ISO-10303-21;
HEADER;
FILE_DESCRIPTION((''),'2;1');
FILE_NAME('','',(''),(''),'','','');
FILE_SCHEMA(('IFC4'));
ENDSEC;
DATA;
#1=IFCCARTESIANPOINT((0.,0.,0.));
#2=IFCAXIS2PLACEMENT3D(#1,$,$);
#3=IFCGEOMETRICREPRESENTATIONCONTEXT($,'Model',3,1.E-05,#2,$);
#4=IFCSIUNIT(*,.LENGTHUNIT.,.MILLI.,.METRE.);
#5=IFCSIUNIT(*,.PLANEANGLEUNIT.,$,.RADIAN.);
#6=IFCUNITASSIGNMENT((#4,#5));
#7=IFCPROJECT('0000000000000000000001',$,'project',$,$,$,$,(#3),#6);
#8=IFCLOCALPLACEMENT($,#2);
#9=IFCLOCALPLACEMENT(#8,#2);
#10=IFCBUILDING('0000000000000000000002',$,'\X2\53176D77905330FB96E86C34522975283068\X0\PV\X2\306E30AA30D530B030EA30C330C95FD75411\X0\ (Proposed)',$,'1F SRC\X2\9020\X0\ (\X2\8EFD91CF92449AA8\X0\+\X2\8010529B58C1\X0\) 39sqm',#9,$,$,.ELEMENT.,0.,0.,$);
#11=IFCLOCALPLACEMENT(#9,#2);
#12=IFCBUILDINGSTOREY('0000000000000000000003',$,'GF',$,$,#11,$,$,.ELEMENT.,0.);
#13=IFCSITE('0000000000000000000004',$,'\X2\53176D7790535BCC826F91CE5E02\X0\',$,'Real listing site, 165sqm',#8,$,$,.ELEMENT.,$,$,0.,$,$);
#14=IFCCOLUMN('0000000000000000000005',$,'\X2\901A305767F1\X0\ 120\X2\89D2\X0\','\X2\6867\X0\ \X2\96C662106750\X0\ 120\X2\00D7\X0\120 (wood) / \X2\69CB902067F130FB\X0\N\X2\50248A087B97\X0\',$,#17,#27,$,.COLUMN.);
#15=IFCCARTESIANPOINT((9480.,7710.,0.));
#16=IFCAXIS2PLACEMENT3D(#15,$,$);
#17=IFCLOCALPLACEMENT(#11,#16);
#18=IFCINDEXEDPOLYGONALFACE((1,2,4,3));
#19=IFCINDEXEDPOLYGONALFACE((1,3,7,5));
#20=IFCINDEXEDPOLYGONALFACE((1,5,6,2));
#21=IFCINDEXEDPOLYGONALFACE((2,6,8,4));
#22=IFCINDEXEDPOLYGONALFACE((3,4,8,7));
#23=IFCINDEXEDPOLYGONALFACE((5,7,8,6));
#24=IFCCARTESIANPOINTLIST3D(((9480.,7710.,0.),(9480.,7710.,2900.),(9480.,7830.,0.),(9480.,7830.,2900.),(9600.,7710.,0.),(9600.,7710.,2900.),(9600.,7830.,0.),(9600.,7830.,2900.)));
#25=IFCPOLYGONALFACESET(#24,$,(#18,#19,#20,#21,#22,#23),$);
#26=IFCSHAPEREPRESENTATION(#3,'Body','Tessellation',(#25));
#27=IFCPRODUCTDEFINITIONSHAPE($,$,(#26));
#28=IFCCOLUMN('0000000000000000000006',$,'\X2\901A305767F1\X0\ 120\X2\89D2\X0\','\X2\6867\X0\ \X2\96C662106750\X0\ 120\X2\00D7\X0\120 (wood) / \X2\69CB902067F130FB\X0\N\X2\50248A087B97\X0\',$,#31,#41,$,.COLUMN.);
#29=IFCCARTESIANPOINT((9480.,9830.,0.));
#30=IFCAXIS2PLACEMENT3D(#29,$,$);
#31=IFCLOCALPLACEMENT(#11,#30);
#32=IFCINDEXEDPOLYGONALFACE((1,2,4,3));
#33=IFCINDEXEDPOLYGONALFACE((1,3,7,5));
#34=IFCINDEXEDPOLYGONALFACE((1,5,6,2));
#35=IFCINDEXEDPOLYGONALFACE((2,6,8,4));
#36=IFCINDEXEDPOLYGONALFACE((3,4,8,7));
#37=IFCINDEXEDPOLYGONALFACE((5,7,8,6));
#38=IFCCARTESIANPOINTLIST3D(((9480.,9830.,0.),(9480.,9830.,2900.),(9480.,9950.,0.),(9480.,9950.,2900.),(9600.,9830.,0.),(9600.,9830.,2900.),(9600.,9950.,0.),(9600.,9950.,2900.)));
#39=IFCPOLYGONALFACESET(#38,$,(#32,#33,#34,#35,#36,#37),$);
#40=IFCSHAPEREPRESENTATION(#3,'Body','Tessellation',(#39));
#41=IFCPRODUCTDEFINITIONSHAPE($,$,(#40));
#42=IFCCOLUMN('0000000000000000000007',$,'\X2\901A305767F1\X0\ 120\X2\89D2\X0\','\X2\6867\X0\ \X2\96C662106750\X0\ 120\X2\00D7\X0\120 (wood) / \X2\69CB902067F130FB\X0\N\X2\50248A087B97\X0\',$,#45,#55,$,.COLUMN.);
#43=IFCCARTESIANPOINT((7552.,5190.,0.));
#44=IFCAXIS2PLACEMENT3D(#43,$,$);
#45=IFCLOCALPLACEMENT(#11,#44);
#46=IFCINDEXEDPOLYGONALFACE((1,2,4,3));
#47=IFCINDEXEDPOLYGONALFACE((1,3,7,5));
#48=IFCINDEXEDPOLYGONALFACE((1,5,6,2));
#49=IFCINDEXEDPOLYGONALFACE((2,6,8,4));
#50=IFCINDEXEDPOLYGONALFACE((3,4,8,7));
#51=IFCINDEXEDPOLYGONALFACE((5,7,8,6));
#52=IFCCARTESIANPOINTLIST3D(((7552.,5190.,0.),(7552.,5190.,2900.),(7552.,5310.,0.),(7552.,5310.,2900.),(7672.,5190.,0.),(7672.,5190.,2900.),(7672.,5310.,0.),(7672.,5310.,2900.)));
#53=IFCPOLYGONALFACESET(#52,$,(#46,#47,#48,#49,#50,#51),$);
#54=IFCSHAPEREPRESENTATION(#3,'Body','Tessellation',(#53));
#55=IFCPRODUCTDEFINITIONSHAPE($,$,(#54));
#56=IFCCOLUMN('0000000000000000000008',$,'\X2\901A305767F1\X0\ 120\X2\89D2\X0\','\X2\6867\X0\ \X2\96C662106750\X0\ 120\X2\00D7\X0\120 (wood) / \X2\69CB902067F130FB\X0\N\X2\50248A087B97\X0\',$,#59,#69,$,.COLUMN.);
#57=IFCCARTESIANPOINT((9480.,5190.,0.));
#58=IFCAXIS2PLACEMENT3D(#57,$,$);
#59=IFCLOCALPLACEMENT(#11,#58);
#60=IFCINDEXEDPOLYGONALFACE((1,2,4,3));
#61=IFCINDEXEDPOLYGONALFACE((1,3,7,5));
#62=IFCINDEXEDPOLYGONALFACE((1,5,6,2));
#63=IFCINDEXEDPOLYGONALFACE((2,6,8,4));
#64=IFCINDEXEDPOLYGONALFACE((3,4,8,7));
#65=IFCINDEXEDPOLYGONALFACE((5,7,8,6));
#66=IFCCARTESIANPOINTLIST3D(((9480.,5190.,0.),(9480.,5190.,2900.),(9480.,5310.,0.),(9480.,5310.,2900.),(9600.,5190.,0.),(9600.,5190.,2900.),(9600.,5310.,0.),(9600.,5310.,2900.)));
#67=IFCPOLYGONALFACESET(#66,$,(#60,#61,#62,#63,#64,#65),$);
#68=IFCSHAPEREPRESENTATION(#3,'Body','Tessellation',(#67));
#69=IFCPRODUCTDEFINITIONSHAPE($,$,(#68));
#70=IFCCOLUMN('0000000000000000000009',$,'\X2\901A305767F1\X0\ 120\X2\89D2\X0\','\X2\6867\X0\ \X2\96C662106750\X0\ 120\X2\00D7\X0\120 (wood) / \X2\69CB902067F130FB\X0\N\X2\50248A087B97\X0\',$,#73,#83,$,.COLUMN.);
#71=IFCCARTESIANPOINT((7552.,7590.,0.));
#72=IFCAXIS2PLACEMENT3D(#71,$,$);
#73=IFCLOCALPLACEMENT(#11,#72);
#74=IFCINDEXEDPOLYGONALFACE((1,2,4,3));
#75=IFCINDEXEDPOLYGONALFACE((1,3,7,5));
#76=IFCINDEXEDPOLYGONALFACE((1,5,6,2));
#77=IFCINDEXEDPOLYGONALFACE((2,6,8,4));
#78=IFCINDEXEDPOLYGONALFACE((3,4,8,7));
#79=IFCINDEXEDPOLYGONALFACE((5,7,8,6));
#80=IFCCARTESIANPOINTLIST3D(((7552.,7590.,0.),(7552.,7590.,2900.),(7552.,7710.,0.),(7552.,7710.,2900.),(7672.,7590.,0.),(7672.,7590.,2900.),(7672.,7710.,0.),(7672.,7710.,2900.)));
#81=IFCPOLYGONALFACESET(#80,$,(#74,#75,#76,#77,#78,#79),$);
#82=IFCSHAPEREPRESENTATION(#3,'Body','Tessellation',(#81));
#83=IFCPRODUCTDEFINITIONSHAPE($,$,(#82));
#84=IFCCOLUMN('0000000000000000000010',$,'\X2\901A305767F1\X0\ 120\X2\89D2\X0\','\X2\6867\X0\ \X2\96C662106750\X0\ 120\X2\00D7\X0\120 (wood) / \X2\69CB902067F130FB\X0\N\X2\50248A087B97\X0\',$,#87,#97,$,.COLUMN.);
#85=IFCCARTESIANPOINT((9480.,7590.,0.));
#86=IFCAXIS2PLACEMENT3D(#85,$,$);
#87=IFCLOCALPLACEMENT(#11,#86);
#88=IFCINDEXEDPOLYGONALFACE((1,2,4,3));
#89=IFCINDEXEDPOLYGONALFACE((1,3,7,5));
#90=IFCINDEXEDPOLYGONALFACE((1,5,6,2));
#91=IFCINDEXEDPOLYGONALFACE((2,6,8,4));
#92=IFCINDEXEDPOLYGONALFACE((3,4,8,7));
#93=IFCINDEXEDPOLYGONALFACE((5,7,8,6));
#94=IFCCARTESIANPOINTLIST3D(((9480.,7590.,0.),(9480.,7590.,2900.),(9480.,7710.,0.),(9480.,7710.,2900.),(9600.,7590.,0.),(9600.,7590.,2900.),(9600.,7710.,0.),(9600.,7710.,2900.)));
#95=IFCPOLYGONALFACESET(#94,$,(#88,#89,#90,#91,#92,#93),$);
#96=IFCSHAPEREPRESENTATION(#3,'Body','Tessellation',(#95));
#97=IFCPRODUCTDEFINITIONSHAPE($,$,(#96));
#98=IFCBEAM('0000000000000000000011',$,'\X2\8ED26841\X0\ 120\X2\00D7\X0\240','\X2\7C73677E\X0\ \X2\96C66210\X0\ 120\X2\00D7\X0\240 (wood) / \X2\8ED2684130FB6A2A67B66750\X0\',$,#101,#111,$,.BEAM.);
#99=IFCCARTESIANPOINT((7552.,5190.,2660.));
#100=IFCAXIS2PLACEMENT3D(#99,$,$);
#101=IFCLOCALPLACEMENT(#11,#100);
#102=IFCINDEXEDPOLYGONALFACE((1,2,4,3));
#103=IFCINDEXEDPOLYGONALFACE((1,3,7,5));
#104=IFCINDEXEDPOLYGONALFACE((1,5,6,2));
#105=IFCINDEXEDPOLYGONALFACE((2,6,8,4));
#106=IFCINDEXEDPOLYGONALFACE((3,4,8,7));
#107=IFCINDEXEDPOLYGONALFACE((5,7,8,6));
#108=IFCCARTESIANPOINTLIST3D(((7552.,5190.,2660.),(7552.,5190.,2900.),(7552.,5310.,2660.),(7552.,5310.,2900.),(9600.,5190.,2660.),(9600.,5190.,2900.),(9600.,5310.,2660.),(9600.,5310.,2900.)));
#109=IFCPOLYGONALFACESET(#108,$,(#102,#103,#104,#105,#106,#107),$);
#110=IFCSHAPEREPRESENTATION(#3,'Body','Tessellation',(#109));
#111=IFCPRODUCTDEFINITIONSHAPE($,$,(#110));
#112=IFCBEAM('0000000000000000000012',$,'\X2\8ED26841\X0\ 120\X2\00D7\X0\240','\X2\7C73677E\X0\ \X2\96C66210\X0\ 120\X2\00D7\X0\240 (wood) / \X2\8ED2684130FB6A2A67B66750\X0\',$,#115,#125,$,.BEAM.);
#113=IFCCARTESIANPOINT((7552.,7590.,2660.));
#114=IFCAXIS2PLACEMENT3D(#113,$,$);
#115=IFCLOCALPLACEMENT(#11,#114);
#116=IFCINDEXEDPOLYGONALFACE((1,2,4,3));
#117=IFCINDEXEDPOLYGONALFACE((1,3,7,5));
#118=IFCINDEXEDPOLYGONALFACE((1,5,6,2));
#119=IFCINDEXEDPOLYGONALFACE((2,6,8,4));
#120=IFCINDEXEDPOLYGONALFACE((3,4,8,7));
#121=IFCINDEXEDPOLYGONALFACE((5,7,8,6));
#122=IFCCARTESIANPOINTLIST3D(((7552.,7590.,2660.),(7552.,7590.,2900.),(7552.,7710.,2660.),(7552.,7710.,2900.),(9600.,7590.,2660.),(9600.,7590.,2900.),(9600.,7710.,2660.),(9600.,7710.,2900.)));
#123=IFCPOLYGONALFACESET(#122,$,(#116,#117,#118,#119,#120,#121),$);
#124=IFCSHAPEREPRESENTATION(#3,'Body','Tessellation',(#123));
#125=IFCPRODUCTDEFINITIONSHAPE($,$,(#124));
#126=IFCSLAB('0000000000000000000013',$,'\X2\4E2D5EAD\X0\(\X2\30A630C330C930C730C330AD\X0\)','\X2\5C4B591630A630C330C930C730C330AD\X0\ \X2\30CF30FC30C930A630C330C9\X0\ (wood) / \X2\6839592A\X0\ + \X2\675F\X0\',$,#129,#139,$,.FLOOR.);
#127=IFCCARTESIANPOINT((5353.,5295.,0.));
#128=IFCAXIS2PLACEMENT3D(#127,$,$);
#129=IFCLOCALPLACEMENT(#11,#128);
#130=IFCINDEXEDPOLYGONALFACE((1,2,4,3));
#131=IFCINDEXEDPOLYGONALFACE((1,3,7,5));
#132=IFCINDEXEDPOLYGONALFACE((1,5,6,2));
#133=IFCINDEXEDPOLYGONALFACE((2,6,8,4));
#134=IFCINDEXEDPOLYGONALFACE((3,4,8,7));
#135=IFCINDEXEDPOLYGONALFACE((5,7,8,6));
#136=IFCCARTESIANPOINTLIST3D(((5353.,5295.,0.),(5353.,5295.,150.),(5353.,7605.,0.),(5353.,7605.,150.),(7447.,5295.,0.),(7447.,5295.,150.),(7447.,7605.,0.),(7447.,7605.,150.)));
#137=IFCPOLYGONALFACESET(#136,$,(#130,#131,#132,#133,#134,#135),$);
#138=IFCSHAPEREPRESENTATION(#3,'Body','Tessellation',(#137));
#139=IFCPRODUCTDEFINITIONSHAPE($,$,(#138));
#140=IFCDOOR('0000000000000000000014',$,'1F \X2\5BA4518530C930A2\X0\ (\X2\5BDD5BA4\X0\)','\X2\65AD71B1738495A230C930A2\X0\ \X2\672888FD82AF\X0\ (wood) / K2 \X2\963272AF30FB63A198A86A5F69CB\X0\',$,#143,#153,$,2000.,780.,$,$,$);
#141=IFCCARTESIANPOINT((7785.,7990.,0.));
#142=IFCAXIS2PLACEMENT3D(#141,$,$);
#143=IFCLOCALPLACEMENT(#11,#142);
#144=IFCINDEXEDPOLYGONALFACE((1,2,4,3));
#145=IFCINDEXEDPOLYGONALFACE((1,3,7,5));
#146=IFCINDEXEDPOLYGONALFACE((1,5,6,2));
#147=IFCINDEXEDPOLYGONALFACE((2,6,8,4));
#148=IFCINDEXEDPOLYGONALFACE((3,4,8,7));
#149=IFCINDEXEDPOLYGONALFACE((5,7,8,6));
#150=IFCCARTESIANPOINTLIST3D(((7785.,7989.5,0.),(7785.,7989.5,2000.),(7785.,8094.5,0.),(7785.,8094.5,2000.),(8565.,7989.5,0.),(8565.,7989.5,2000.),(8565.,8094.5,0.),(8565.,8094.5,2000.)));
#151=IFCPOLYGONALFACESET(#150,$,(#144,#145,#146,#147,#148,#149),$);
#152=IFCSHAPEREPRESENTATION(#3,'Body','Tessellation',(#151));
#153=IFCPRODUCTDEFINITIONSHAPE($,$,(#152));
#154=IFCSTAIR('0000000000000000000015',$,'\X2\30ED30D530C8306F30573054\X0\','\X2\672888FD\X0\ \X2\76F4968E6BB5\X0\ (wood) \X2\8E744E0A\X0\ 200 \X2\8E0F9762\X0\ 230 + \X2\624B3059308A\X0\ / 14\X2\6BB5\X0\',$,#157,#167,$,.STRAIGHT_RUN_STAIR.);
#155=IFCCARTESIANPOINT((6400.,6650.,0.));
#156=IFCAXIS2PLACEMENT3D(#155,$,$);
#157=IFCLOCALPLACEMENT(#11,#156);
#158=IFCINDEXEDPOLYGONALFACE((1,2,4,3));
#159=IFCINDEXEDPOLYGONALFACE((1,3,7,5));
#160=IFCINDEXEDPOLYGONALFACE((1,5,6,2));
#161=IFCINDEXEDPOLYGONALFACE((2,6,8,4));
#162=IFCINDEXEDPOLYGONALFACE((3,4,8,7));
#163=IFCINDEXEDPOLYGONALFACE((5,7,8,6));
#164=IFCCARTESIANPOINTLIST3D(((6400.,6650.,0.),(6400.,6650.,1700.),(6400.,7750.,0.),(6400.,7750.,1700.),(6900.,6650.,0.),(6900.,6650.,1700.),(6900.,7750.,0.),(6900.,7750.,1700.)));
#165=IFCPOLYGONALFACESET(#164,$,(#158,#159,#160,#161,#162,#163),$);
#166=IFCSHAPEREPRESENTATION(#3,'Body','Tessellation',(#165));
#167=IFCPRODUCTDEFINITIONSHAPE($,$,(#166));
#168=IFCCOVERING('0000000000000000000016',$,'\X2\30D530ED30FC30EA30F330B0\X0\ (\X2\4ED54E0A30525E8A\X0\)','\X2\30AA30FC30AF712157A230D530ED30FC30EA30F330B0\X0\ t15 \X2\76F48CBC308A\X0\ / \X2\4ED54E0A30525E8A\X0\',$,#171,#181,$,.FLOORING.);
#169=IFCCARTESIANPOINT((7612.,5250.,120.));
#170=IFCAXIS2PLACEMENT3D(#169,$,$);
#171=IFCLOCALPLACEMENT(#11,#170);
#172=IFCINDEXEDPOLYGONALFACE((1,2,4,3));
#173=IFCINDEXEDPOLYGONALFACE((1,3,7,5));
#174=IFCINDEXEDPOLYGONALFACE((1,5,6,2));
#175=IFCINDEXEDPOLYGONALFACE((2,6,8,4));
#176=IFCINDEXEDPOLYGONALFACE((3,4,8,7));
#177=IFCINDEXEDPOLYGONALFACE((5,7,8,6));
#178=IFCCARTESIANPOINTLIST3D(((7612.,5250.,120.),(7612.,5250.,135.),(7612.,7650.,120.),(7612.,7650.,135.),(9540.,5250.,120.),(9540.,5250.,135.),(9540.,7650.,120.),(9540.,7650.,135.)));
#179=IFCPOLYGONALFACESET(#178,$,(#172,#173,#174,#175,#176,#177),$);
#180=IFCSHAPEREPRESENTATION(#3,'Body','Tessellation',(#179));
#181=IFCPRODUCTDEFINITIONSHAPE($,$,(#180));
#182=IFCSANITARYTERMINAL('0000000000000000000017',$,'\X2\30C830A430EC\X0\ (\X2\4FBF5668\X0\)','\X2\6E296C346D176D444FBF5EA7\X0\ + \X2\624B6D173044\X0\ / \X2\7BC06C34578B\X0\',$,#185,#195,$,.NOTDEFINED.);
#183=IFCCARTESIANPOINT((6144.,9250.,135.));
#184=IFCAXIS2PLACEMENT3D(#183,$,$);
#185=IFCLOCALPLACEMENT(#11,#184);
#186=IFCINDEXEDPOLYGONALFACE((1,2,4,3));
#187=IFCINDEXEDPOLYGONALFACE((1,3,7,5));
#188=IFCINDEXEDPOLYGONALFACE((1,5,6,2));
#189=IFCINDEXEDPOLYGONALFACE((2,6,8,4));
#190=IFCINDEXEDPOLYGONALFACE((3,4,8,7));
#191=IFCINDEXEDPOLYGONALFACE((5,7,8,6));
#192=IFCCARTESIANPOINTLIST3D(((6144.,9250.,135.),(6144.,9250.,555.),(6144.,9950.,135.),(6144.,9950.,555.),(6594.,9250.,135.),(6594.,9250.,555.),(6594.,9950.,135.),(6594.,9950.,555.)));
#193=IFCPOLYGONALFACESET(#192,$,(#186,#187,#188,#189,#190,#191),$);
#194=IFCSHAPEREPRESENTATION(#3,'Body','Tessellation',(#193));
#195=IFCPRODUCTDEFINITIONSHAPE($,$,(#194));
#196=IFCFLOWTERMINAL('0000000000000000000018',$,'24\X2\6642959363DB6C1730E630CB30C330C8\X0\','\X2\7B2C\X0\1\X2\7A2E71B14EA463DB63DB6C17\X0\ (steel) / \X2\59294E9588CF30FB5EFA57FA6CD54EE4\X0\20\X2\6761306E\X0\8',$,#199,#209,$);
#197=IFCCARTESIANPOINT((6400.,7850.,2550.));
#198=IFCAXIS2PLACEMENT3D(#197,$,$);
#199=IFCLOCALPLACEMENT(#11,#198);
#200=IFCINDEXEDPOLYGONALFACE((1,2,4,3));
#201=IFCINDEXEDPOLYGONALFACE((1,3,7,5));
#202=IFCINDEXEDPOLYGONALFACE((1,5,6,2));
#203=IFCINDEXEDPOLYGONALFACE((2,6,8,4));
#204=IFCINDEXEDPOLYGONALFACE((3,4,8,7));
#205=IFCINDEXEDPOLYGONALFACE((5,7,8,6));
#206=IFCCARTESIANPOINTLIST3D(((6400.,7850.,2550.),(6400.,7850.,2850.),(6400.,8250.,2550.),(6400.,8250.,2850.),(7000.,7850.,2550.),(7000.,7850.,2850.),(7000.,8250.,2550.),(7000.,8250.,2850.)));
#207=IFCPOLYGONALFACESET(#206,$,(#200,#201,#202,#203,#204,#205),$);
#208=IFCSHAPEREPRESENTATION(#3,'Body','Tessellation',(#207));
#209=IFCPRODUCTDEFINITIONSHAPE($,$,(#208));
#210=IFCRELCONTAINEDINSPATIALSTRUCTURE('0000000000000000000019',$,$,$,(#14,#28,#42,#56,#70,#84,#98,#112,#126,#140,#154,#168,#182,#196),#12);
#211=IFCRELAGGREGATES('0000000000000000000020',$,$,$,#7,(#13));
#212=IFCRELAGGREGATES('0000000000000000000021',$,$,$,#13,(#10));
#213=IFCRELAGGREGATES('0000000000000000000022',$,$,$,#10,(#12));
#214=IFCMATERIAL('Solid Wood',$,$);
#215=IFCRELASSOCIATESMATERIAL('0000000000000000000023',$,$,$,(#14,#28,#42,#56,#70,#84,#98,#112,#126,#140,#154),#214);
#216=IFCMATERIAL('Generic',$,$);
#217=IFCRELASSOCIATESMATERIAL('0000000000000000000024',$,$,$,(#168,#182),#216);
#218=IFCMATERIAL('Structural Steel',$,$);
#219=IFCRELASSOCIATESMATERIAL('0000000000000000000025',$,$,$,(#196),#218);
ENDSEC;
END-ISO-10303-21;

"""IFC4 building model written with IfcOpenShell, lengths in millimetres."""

from ifc_helpers import new_model, si_unit, frame, frame_2d, origin, place, context, project, spatial, rectangle, extrude, material, element, save


model = new_model("IFC4")

# Units and contexts
model_context = context("Model", 3, precision=1e-05, world=origin())
ifc_project = project(units=[si_unit("LENGTHUNIT", "METRE", prefix="MILLI"), si_unit("PLANEANGLEUNIT", "RADIAN")], contexts=[model_context])

# Site, building, storey
site_placement = place(None, origin())
site = spatial("IfcSite", under=ifc_project, at=site_placement, Name="北海道富良野市", ObjectType="Real listing site, 165sqm", CompositionType="ELEMENT", RefElevation=0.0)
building_placement = place(site_placement, origin())
building = spatial("IfcBuilding", under=site, at=building_placement, Name="北海道・雨水利用とPVのオフグリッド志向 (Proposed)", ObjectType="1F SRC造 (軽量鉄骨+耐力壁) 39sqm", CompositionType="ELEMENT", ElevationOfRefHeight=0.0, ElevationOfTerrain=0.0)
storey_placement = place(building_placement, origin())
storey = spatial("IfcBuildingStorey", under=building, at=storey_placement, Name="GF", CompositionType="ELEMENT", Elevation=0.0)

# Columns
ifc_material_1 = material(Name="Solid Wood")
column_1_placement = place(storey_placement, frame((9480.0, 7710.0, 0.0)))
element("IfcColumn", 1, at=column_1_placement, inside=storey, material=ifc_material_1, Name="通し柱 120角", Description="桧 集成材 120×120 (wood) / 構造柱・N値計算", PredefinedType="COLUMN", context=model_context, shape_type="SweptSolid", body=[
    extrude(rectangle(XDim=120.0, YDim=120.0, at=frame_2d((60.0, 60.0))), frame((9480.0, 7710.0, 0.0)), (0.0, 0.0, 1.0), 2900.0),
])
column_2_placement = place(storey_placement, frame((9480.0, 9830.0, 0.0)))
element("IfcColumn", 2, at=column_2_placement, inside=storey, material=ifc_material_1, Name="通し柱 120角", Description="桧 集成材 120×120 (wood) / 構造柱・N値計算", PredefinedType="COLUMN", context=model_context, shape_type="SweptSolid", body=[
    extrude(rectangle(XDim=120.0, YDim=120.0, at=frame_2d((60.0, 60.0))), frame((9480.0, 9830.0, 0.0)), (0.0, 0.0, 1.0), 2900.0),
])
column_3_placement = place(storey_placement, frame((7552.0, 5190.0, 0.0)))
element("IfcColumn", 3, at=column_3_placement, inside=storey, material=ifc_material_1, Name="通し柱 120角", Description="桧 集成材 120×120 (wood) / 構造柱・N値計算", PredefinedType="COLUMN", context=model_context, shape_type="SweptSolid", body=[
    extrude(rectangle(XDim=120.0, YDim=120.0, at=frame_2d((60.0, 60.0))), frame((7552.0, 5190.0, 0.0)), (0.0, 0.0, 1.0), 2900.0),
])
column_4_placement = place(storey_placement, frame((9480.0, 5190.0, 0.0)))
element("IfcColumn", 4, at=column_4_placement, inside=storey, material=ifc_material_1, Name="通し柱 120角", Description="桧 集成材 120×120 (wood) / 構造柱・N値計算", PredefinedType="COLUMN", context=model_context, shape_type="SweptSolid", body=[
    extrude(rectangle(XDim=120.0, YDim=120.0, at=frame_2d((60.0, 60.0))), frame((9480.0, 5190.0, 0.0)), (0.0, 0.0, 1.0), 2900.0),
])
column_5_placement = place(storey_placement, frame((7552.0, 7590.0, 0.0)))
element("IfcColumn", 5, at=column_5_placement, inside=storey, material=ifc_material_1, Name="通し柱 120角", Description="桧 集成材 120×120 (wood) / 構造柱・N値計算", PredefinedType="COLUMN", context=model_context, shape_type="SweptSolid", body=[
    extrude(rectangle(XDim=120.0, YDim=120.0, at=frame_2d((60.0, 60.0))), frame((7552.0, 7590.0, 0.0)), (0.0, 0.0, 1.0), 2900.0),
])
column_6_placement = place(storey_placement, frame((9480.0, 7590.0, 0.0)))
element("IfcColumn", 6, at=column_6_placement, inside=storey, material=ifc_material_1, Name="通し柱 120角", Description="桧 集成材 120×120 (wood) / 構造柱・N値計算", PredefinedType="COLUMN", context=model_context, shape_type="SweptSolid", body=[
    extrude(rectangle(XDim=120.0, YDim=120.0, at=frame_2d((60.0, 60.0))), frame((9480.0, 7590.0, 0.0)), (0.0, 0.0, 1.0), 2900.0),
])

# Beams
beam_1_placement = place(storey_placement, frame((7552.0, 5190.0, 2660.0)))
element("IfcBeam", 7, at=beam_1_placement, inside=storey, material=ifc_material_1, Name="軒桁 120×240", Description="米松 集成 120×240 (wood) / 軒桁・横架材", PredefinedType="BEAM", context=model_context, shape_type="SweptSolid", body=[
    extrude(rectangle(XDim=2048.0, YDim=120.0, at=frame_2d((1024.0, 60.0))), frame((7552.0, 5190.0, 2660.0)), (0.0, 0.0, 1.0), 240.0),
])
beam_2_placement = place(storey_placement, frame((7552.0, 7590.0, 2660.0)))
element("IfcBeam", 8, at=beam_2_placement, inside=storey, material=ifc_material_1, Name="軒桁 120×240", Description="米松 集成 120×240 (wood) / 軒桁・横架材", PredefinedType="BEAM", context=model_context, shape_type="SweptSolid", body=[
    extrude(rectangle(XDim=2048.0, YDim=120.0, at=frame_2d((1024.0, 60.0))), frame((7552.0, 7590.0, 2660.0)), (0.0, 0.0, 1.0), 240.0),
])

# Slab
slab_placement = place(storey_placement, frame((5353.0, 5295.0, 0.0)))
element("IfcSlab", 9, at=slab_placement, inside=storey, material=ifc_material_1, Name="中庭(ウッドデッキ)", Description="屋外ウッドデッキ ハードウッド (wood) / 根太 + 束", PredefinedType="FLOOR", context=model_context, shape_type="SweptSolid", body=[
    extrude(rectangle(XDim=2094.0, YDim=2310.0, at=frame_2d((1047.0, 1155.0))), frame((5353.0, 5295.0, 0.0)), (0.0, 0.0, 1.0), 150.0),
])

# Door
door_placement = place(storey_placement, frame((7785.0, 7990.0, 0.0)))
element("IfcDoor", 10, at=door_placement, inside=storey, material=ifc_material_1, Name="1F 室内ドア (寝室)", Description="断熱玄関ドア 木製芯 (wood) / K2 防犯・採風機構", OverallHeight=2000.0, OverallWidth=780.0, context=model_context, shape_type="SweptSolid", body=[
    extrude(rectangle(XDim=780.0, YDim=105.0, at=frame_2d((390.0, 52.0))), frame((7785.0, 7990.0, 0.0)), (0.0, 0.0, 1.0), 2000.0),
])

# Stair
stair_placement = place(storey_placement, frame((6400.0, 6650.0, 0.0)))
element("IfcStair", 11, at=stair_placement, inside=storey, material=ifc_material_1, Name="ロフトはしご", Description="木製 直階段 (wood) 蹴上 200 踏面 230 + 手すり / 14段", PredefinedType="STRAIGHT_RUN_STAIR", context=model_context, shape_type="SweptSolid", body=[
    extrude(rectangle(XDim=500.0, YDim=1100.0, at=frame_2d((250.0, 550.0))), frame((6400.0, 6650.0, 0.0)), (0.0, 0.0, 1.0), 1700.0),
])

# Covering
ifc_material_2 = material(Name="Generic")
covering_placement = place(storey_placement, frame((7612.0, 5250.0, 120.0)))
element("IfcCovering", 12, at=covering_placement, inside=storey, material=ifc_material_2, Name="フローリング (仕上げ床)", Description="オーク無垢フローリング t15 直貼り / 仕上げ床", PredefinedType="FLOORING", context=model_context, shape_type="SweptSolid", body=[
    extrude(rectangle(XDim=1928.0, YDim=2400.0, at=frame_2d((964.0, 1200.0))), frame((7612.0, 5250.0, 120.0)), (0.0, 0.0, 1.0), 15.0),
])

# Sanitary terminal
sanitary_terminal_placement = place(storey_placement, frame((6144.0, 9250.0, 135.0)))
element("IfcSanitaryTerminal", 13, at=sanitary_terminal_placement, inside=storey, material=ifc_material_2, Name="トイレ (便器)", Description="温水洗浄便座 + 手洗い / 節水型", PredefinedType="NOTDEFINED", context=model_context, shape_type="SweptSolid", body=[
    extrude(rectangle(XDim=450.0, YDim=700.0, at=frame_2d((225.0, 350.0))), frame((6144.0, 9250.0, 135.0)), (0.0, 0.0, 1.0), 420.0),
])

# Flow terminal
ifc_material_3 = material(Name="Structural Steel")
flow_terminal_placement = place(storey_placement, frame((6400.0, 7850.0, 2550.0)))
element("IfcFlowTerminal", 14, at=flow_terminal_placement, inside=storey, material=ifc_material_3, Name="24時間換気ユニット", Description="第1種熱交換換気 (steel) / 天井裏・建基法令20条の8", context=model_context, shape_type="SweptSolid", body=[
    extrude(rectangle(XDim=600.0, YDim=400.0, at=frame_2d((300.0, 200.0))), frame((6400.0, 7850.0, 2550.0)), (0.0, 0.0, 1.0), 300.0),
])

save(model, "model.ifc")
